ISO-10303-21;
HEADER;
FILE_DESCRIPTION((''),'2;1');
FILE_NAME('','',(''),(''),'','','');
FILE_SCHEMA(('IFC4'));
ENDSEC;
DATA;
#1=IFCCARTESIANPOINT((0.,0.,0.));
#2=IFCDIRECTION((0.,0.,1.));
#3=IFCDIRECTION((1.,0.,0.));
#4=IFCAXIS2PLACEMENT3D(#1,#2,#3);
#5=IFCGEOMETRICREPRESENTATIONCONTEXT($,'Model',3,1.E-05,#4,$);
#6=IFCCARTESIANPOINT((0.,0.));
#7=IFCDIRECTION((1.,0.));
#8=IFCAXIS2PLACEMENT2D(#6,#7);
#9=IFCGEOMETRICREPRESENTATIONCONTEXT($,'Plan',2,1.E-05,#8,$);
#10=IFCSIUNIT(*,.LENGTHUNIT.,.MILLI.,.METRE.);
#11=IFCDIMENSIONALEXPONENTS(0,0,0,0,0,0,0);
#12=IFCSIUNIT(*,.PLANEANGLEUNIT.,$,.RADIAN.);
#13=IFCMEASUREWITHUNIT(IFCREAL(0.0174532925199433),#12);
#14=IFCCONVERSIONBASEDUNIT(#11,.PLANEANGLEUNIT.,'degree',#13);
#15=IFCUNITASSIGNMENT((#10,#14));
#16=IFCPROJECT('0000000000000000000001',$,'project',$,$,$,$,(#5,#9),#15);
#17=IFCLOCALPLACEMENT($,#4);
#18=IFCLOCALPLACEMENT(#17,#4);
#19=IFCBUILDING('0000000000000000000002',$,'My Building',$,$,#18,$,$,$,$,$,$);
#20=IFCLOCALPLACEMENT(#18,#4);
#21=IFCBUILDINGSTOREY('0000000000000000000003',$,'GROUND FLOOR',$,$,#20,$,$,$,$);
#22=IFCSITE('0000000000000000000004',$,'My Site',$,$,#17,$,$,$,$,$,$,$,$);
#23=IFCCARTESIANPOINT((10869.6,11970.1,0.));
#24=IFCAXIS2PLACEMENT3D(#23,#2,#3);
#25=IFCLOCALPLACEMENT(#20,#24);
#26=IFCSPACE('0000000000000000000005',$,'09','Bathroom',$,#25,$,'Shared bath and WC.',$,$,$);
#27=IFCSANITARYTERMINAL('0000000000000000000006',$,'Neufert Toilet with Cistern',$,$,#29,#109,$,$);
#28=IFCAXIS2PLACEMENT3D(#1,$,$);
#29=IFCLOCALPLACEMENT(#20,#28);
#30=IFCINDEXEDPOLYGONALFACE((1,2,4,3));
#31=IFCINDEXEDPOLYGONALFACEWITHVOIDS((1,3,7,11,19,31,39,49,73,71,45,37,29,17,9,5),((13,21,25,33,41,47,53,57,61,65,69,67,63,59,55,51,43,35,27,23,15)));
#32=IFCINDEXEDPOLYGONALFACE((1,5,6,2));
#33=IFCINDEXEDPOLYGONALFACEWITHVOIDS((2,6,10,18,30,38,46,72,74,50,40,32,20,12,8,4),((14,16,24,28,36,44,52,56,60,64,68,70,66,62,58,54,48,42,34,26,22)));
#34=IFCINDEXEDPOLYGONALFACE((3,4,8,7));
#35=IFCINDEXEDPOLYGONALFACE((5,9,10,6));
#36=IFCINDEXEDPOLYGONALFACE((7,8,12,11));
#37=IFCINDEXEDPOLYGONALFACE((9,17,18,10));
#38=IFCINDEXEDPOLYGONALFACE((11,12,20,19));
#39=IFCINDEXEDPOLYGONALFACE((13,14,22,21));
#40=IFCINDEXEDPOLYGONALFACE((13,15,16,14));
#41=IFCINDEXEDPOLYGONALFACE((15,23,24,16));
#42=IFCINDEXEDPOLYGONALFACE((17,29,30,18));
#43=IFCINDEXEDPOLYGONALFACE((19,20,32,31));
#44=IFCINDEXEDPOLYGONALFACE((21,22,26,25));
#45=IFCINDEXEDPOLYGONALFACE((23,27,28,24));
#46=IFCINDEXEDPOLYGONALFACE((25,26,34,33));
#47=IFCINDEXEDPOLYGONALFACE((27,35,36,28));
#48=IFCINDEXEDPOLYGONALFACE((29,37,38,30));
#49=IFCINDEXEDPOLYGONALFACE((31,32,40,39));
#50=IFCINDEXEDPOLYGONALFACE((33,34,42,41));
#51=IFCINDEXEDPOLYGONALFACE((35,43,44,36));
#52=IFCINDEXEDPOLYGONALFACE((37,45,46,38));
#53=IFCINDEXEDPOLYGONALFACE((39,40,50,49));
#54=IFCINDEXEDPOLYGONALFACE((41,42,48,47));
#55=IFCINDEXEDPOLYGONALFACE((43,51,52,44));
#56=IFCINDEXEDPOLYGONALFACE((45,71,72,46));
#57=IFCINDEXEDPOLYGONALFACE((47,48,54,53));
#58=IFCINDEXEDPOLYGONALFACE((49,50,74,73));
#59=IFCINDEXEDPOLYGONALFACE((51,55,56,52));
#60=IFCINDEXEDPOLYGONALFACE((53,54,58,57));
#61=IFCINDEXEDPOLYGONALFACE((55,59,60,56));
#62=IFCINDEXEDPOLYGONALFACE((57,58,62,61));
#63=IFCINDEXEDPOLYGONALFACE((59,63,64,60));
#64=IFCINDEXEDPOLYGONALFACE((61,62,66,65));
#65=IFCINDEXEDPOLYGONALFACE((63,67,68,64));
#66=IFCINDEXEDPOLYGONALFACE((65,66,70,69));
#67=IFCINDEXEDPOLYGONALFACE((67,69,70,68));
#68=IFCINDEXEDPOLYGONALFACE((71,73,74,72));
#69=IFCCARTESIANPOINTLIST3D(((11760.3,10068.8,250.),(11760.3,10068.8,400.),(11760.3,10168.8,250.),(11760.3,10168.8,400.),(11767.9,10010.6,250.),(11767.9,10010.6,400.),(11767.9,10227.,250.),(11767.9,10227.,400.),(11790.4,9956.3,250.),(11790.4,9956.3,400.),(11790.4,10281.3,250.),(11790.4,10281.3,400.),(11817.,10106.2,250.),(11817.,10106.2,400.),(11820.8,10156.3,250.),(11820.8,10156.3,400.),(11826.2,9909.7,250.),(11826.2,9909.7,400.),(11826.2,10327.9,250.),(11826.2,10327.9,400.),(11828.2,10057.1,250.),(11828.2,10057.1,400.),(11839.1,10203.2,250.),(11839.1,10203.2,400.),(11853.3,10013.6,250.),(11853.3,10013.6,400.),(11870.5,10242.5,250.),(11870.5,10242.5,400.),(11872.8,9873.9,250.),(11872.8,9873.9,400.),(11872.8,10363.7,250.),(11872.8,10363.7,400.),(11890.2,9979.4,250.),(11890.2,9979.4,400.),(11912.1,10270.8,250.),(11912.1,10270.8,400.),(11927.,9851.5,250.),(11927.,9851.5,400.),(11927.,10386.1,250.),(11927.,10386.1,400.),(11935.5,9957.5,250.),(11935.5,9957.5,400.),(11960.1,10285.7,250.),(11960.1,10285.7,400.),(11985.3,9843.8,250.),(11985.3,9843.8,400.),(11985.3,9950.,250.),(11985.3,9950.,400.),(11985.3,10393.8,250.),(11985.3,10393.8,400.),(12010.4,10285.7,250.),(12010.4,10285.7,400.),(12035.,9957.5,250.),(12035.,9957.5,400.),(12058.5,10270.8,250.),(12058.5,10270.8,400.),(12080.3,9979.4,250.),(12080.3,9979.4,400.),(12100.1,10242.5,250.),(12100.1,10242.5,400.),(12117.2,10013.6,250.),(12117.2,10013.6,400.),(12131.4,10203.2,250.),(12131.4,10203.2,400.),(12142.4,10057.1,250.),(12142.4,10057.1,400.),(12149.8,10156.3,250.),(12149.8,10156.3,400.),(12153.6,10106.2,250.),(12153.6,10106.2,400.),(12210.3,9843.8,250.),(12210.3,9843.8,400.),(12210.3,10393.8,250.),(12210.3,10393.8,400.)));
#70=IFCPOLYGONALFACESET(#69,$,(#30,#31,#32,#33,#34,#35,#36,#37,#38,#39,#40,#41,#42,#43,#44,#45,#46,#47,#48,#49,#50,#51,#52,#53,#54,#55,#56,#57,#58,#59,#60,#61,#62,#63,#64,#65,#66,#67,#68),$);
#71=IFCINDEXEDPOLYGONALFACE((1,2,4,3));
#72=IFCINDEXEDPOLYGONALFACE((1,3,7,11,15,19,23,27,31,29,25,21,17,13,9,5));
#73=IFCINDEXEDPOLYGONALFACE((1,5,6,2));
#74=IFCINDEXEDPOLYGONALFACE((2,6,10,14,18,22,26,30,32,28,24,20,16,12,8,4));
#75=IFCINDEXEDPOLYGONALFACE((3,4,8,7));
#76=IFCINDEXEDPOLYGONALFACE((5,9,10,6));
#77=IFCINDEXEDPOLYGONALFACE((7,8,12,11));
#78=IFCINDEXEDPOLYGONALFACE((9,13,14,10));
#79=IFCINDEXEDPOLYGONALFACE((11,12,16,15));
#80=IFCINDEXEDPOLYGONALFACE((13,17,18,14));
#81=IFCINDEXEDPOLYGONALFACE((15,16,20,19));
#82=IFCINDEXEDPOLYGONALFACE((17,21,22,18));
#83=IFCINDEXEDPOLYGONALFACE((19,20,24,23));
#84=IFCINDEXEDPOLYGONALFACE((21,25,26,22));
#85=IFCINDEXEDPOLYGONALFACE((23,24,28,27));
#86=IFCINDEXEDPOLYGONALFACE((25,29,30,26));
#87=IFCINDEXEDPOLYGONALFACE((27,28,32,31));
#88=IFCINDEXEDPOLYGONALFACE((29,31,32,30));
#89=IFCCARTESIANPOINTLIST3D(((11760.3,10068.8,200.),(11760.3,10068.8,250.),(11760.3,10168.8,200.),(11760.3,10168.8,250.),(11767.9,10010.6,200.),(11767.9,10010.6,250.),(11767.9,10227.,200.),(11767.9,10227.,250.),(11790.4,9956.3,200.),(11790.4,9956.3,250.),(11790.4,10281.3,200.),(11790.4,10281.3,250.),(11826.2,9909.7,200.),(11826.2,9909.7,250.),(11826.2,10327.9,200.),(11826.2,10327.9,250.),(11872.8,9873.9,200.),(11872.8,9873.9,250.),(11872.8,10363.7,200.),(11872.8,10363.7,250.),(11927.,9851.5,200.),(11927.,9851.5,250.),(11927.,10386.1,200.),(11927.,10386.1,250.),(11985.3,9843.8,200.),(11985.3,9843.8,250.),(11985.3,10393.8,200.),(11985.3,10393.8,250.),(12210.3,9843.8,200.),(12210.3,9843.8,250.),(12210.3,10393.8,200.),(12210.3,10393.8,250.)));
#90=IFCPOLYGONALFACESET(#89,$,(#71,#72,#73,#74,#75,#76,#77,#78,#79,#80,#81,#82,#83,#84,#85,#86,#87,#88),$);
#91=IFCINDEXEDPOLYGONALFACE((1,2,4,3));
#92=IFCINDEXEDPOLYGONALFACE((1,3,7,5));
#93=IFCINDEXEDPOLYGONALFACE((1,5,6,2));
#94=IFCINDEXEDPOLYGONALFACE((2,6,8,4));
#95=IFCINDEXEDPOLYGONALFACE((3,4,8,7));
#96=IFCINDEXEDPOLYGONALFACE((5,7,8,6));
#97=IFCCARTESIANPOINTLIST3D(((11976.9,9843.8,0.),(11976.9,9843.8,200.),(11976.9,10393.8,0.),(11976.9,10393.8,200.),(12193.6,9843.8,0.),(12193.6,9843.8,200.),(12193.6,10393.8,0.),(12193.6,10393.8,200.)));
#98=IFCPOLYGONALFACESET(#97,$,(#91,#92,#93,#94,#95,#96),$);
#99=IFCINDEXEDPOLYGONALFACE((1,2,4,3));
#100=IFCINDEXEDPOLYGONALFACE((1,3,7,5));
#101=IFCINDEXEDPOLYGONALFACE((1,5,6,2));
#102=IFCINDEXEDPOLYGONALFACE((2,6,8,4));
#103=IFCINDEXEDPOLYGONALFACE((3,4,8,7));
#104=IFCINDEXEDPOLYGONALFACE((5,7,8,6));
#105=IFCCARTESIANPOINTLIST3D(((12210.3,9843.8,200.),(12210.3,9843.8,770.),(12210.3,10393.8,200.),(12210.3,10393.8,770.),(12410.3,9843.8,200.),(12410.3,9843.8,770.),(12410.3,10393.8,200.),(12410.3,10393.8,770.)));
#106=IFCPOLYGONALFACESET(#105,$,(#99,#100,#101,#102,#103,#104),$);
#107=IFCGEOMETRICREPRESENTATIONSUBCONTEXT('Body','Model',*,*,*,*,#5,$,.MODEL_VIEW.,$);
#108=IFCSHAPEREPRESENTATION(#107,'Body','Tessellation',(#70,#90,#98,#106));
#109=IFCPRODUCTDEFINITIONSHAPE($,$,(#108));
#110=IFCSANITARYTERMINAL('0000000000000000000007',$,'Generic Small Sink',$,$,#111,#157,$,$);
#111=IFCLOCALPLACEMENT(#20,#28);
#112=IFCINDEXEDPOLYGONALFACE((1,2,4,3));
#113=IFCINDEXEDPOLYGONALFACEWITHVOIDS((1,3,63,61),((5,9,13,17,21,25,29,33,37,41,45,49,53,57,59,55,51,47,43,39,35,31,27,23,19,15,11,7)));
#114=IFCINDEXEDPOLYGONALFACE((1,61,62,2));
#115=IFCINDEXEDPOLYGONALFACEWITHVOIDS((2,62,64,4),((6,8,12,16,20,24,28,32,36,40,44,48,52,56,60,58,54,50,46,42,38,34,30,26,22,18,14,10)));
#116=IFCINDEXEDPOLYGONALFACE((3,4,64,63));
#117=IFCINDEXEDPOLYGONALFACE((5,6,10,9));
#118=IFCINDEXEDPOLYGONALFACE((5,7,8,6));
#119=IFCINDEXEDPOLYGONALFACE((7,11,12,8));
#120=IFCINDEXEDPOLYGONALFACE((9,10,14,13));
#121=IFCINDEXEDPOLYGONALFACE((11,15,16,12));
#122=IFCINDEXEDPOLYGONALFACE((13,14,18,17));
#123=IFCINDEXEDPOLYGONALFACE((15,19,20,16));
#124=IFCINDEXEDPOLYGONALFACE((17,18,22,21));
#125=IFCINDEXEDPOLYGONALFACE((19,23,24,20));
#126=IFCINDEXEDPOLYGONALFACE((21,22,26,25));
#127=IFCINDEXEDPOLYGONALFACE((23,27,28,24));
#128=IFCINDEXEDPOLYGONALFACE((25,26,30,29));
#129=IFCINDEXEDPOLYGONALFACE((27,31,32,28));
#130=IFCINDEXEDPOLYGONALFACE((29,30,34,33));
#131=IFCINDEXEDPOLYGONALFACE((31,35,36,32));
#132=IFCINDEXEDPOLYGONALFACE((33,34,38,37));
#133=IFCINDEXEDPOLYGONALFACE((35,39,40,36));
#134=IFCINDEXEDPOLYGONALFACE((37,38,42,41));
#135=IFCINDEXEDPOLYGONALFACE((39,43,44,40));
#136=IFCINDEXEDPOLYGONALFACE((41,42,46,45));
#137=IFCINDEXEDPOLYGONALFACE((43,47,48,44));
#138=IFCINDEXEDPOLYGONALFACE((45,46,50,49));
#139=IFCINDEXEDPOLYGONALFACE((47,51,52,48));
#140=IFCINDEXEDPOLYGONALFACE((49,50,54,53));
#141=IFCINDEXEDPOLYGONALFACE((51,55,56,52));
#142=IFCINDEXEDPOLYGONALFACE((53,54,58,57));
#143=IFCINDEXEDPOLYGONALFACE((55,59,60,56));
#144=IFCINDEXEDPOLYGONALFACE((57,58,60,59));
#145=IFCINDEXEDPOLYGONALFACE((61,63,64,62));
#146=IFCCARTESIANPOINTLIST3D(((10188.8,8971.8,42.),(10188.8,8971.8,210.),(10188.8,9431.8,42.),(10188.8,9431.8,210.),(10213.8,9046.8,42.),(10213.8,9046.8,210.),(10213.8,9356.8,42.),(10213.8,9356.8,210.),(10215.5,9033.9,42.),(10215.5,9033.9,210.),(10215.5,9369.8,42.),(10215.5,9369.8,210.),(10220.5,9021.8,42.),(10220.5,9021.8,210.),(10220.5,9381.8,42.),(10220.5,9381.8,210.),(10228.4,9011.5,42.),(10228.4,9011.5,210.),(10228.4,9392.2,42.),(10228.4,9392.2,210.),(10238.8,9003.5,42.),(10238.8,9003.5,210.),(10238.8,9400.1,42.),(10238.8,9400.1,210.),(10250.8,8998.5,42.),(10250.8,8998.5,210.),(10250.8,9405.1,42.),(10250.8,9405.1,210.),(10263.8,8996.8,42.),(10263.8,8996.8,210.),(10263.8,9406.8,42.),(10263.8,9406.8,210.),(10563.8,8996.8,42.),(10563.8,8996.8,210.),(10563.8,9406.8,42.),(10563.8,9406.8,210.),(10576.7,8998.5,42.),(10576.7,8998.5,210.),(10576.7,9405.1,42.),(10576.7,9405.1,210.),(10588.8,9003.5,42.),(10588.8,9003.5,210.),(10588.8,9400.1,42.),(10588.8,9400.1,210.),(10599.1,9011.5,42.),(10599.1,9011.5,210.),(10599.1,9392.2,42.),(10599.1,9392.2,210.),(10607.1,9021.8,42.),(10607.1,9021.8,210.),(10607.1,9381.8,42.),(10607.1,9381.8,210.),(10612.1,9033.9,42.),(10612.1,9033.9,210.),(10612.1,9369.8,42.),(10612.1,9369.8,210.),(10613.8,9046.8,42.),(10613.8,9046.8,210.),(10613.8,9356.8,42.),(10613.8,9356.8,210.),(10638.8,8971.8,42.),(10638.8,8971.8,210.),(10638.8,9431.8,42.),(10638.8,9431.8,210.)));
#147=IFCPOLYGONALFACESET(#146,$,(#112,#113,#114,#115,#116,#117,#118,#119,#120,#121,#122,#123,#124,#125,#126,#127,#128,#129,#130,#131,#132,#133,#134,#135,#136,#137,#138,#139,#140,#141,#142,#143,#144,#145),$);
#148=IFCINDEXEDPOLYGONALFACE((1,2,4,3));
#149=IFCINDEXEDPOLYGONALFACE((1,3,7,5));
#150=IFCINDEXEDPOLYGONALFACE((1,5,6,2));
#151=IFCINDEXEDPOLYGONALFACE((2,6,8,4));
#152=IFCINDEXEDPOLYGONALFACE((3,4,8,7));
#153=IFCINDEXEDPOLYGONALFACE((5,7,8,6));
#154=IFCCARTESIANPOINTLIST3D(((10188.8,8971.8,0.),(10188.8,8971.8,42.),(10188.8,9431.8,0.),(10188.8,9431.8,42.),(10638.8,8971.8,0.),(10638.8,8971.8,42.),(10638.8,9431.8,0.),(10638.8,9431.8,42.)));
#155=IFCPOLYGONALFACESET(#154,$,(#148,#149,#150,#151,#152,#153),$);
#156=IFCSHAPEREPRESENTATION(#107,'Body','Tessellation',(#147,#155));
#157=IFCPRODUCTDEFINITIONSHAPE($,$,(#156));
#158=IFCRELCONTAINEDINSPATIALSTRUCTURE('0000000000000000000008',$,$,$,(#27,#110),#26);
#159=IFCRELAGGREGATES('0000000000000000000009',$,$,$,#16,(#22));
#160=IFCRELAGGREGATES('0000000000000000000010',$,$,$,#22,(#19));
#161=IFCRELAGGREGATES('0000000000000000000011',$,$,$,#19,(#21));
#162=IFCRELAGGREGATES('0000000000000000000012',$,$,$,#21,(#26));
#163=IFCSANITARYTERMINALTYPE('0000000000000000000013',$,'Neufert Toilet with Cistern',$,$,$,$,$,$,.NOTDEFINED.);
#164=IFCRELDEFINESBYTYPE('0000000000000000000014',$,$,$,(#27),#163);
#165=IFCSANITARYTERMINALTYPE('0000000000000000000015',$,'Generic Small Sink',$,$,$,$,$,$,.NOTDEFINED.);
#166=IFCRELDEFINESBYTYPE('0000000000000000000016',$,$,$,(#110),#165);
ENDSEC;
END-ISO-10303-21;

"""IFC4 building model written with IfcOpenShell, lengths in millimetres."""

from ifc_helpers import new_model, entity, si_unit, converted_unit, frame, frame_2d, origin_with_axes, origin_2d_with_axis, place, context, subcontext, project, spatial, line, arc, indexed_curve, circle_curve, outline, extrude, shape, source, transform, mapped, type_object, type_shapes, element, save


model = new_model("IFC4")

# Units and contexts
model_context = context("Model", 3, precision=1e-05, world=origin_with_axes())
plan_context = context("Plan", 2, precision=1e-05, world=origin_2d_with_axis())
body_context_1 = subcontext(model_context, "Body", "Model", "MODEL_VIEW")
body_context_2 = subcontext(plan_context, "Body", "Plan", "PLAN_VIEW")
ifc_project = project(units=[si_unit("LENGTHUNIT", "METRE", prefix="MILLI"), converted_unit("PLANEANGLEUNIT", "degree", entity("IfcReal", 0.0174532925199433), si_unit("PLANEANGLEUNIT", "RADIAN"), dimensions=[0, 0, 0, 0, 0, 0, 0])], contexts=[model_context, plan_context])

# Site, building, storey
site_placement = place(None, origin_with_axes())
site = spatial("IfcSite", under=ifc_project, at=site_placement, Name="My Site")
building_placement = place(site_placement, origin_with_axes())
building = spatial("IfcBuilding", under=site, at=building_placement, Name="My Building")
storey_placement = place(building_placement, origin_with_axes())
storey = spatial("IfcBuildingStorey", under=building, at=storey_placement, Name="GROUND FLOOR")

# Shared definitions
space_1_placement = place(storey_placement, frame((10869.6, 11970.1, 0.0), z_axis=(0.0, 0.0, 1.0), x_axis=(1.0, 0.0, 0.0)))
space_1 = spatial("IfcSpace", under=storey, at=space_1_placement, Name="09", Description="Bathroom", LongName="Shared bath and WC.")

# Sanitary terminals
sanitary_terminal_type_1 = type_object("IfcSanitaryTerminalType", Name="Neufert Toilet with Cistern", PredefinedType="NOTDEFINED")
shared_shape_1 = source(origin_with_axes(), body_context_1, "Body", "SweptSolid", [
    extrude(outline(indexed_curve([(-275.0, -200.0), (275.0, -200.0), (275.0, -425.0), (209.1, -584.1), (50.0, -650.0), (-50.0, -650.0), (-209.1, -584.1), (-275.0, -425.0)], segments=[line(1, 2), line(2, 3), arc(3, 4, 5), line(5, 6), arc(6, 7, 8), line(8, 1)]), holes=[circle_curve(frame_2d((0.0, -425.0)), 168.8)]), frame((0.0, 0.0, 250.0), z_axis=(0.0, 0.0, 1.0), x_axis=(1.0, 0.0, 0.0)), (0.0, 0.0, 1.0), 150.0),
    extrude(outline(indexed_curve([(-275.0, -200.0), (275.0, -200.0), (275.0, -425.0), (209.1, -584.1), (50.0, -650.0), (-50.0, -650.0), (-209.1, -584.1), (-275.0, -425.0)], segments=[line(1, 2), line(2, 3), arc(3, 4, 5), line(5, 6), arc(6, 7, 8), line(8, 1)])), frame((0.0, 0.0, 200.0), z_axis=(0.0, 0.0, 1.0), x_axis=(1.0, 0.0, 0.0)), (0.0, 0.0, 1.0), 50.0),
    extrude(outline(indexed_curve([(-275.0, -216.7), (275.0, -216.7), (275.0, -433.3), (-275.0, -433.3)], segments=[line(1, 2, 3, 4, 1)])), origin_with_axes(), (0.0, 0.0, 1.0), 200.0),
    extrude(outline(indexed_curve([(-275.0, 0.0), (275.0, 0.0), (275.0, -200.0), (-275.0, -200.0)], segments=[line(1, 2, 3, 4, 1)])), frame((0.0, 0.0, 200.0), z_axis=(0.0, 0.0, 1.0), x_axis=(1.0, 0.0, 0.0)), (0.0, 0.0, 1.0), 570.0),
])
shared_shape_2 = source(origin_with_axes(), body_context_2, "Body", "Curve2D", [
    entity("IfcIndexedPolyCurve", entity("IfcCartesianPointList2D", [[-275.0, 0.0], [275.0, 0.0], [275.0, -200.0], [-275.0, -200.0]]), [entity("IfcLineIndex", [1, 2, 3, 4, 1])]),
    entity("IfcIndexedPolyCurve", entity("IfcCartesianPointList2D", [[165.0, -200.0], [192.5, -335.0]])),
    entity("IfcTrimmedCurve", entity("IfcEllipse", entity("IfcAxis2Placement2D", entity("IfcCartesianPoint", [0.0, -335.0]), entity("IfcDirection", [1.0, 0.0])), 192.5, 315.0), [entity("IfcCartesianPoint", [-192.5, -335.0])], [entity("IfcCartesianPoint", [192.5, -335.0])], True, "CARTESIAN"),
    entity("IfcIndexedPolyCurve", entity("IfcCartesianPointList2D", [[-165.0, -200.0], [-192.5, -335.0]])),
    entity("IfcEllipse", entity("IfcAxis2Placement2D", entity("IfcCartesianPoint", [0.0, -452.0]), entity("IfcDirection", [1.0, 0.0])), 131.2, 157.5),
    entity("IfcIndexedPolyCurve", entity("IfcCartesianPointList2D", [[-34.4, -452.0], [-34.4, -429.5], [34.4, -429.5], [34.4, -452.0]])),
    entity("IfcTrimmedCurve", entity("IfcEllipse", entity("IfcAxis2Placement2D", entity("IfcCartesianPoint", [0.0, -452.0]), entity("IfcDirection", [1.0, 0.0])), 34.4, 22.5), [entity("IfcCartesianPoint", [-34.4, -452.0])], [entity("IfcCartesianPoint", [34.4, -452.0])], True, "CARTESIAN"),
])
type_shapes(sanitary_terminal_type_1, [shared_shape_1, shared_shape_2])
sanitary_terminal_1_placement = place(space_1_placement, frame((1540.7, -1851.3, 0.0), z_axis=(0.0, 0.0, 1.0), x_axis=(0.0, -1.0, 0.0)))
element("IfcSanitaryTerminal", 1, at=sanitary_terminal_1_placement, inside=space_1, type_object=sanitary_terminal_type_1, Name="Neufert Toilet with Cistern", shapes=[
    shape(body_context_1, "Body", "MappedRepresentation", [mapped(shared_shape_1, transform((0.0, 0.0, 0.0), x_axis=(1.0, 0.0, 0.0), y_axis=(0.0, 1.0, 0.0), z_axis=(0.0, 0.0, 1.0), scale=1.0))]),
    shape(body_context_2, "Body", "MappedRepresentation", [mapped(shared_shape_2, transform((0.0, 0.0, 0.0), x_axis=(1.0, 0.0, 0.0), y_axis=(0.0, 1.0, 0.0), z_axis=(0.0, 0.0, 1.0), scale=1.0))]),
])
sanitary_terminal_type_2 = type_object("IfcSanitaryTerminalType", Name="Generic Small Sink", PredefinedType="NOTDEFINED")
shared_indexed_poly_curve = entity("IfcIndexedPolyCurve", entity("IfcCartesianPointList2D", [[0.0, 0.0], [450.0, 0.0], [450.0, 460.0], [0.0, 460.0]]), [entity("IfcLineIndex", [1, 2, 3, 4, 1])])
shared_shape_3 = source(origin_with_axes(), body_context_1, "Body", "SweptSolid", [
    entity("IfcExtrudedAreaSolid", entity("IfcArbitraryProfileDefWithVoids", "AREA", None, shared_indexed_poly_curve, [entity("IfcIndexedPolyCurve", entity("IfcCartesianPointList2D", [[25.0, 75.0], [39.6, 39.6], [75.0, 25.0], [375.0, 25.0], [410.4, 39.6], [425.0, 75.0], [425.0, 385.0], [410.4, 420.4], [375.0, 435.0], [75.0, 435.0], [39.6, 420.4], [25.0, 385.0]]), [entity("IfcLineIndex", [12, 1]), entity("IfcArcIndex", [1, 2, 3]), entity("IfcLineIndex", [3, 4]), entity("IfcArcIndex", [4, 5, 6]), entity("IfcLineIndex", [6, 7]), entity("IfcArcIndex", [7, 8, 9]), entity("IfcLineIndex", [9, 10]), entity("IfcArcIndex", [10, 11, 12]), entity("IfcLineIndex", [12, 1])])]), entity("IfcAxis2Placement3D", entity("IfcCartesianPoint", [-225.0, -460.0, 42.0]), entity("IfcDirection", [0.0, 0.0, 1.0]), entity("IfcDirection", [1.0, 0.0, 0.0])), entity("IfcDirection", [0.0, 0.0, 1.0]), 168.0),
    entity("IfcExtrudedAreaSolid", entity("IfcArbitraryClosedProfileDef", "AREA", None, shared_indexed_poly_curve), entity("IfcAxis2Placement3D", entity("IfcCartesianPoint", [-225.0, -460.0, 0.0]), entity("IfcDirection", [0.0, 0.0, 1.0]), entity("IfcDirection", [1.0, 0.0, 0.0])), entity("IfcDirection", [0.0, 0.0, 1.0]), 42.0),
])
shared_shape_4 = source(origin_with_axes(), body_context_2, "Body", "Curve2D", [
    entity("IfcIndexedPolyCurve", entity("IfcCartesianPointList2D", [[-225.0, -460.0], [225.0, -460.0], [225.0, 0.0], [-225.0, 0.0]]), [entity("IfcLineIndex", [1, 2, 3, 4, 1])]),
    entity("IfcIndexedPolyCurve", entity("IfcCartesianPointList2D", [[-200.0, -385.0], [-185.4, -420.4], [-150.0, -435.0], [150.0, -435.0], [185.4, -420.4], [200.0, -385.0], [200.0, -75.0], [185.4, -39.6], [150.0, -25.0], [-150.0, -25.0], [-185.4, -39.6], [-200.0, -75.0]]), [entity("IfcLineIndex", [12, 1]), entity("IfcArcIndex", [1, 2, 3]), entity("IfcLineIndex", [3, 4]), entity("IfcArcIndex", [4, 5, 6]), entity("IfcLineIndex", [6, 7]), entity("IfcArcIndex", [7, 8, 9]), entity("IfcLineIndex", [9, 10]), entity("IfcArcIndex", [10, 11, 12]), entity("IfcLineIndex", [12, 1])]),
    entity("IfcCircle", entity("IfcAxis2Placement2D", entity("IfcCartesianPoint", [0.0, -125.0])), 25.0),
    entity("IfcIndexedPolyCurve", entity("IfcCartesianPointList2D", [[0.0, -12.5], [0.0, -132.5]])),
])
type_shapes(sanitary_terminal_type_2, [shared_shape_3, shared_shape_4])
sanitary_terminal_2_placement = place(space_1_placement, frame((-455.8, -2998.3, 0.0), z_axis=(0.0, 0.0, 1.0), x_axis=(-1.0, 0.0, 0.0)))
element("IfcSanitaryTerminal", 2, at=sanitary_terminal_2_placement, inside=space_1, type_object=sanitary_terminal_type_2, Name="Generic Small Sink", shapes=[
    shape(body_context_1, "Body", "MappedRepresentation", [mapped(shared_shape_3, transform((0.0, 0.0, 0.0), x_axis=(1.0, 0.0, 0.0), y_axis=(0.0, 1.0, 0.0), z_axis=(0.0, 0.0, 1.0), scale=1.0))]),
    shape(body_context_2, "Body", "MappedRepresentation", [mapped(shared_shape_4, transform((0.0, 0.0, 0.0), x_axis=(1.0, 0.0, 0.0), y_axis=(0.0, 1.0, 0.0), z_axis=(0.0, 0.0, 1.0), scale=1.0))]),
])

save(model, "model.ifc")
